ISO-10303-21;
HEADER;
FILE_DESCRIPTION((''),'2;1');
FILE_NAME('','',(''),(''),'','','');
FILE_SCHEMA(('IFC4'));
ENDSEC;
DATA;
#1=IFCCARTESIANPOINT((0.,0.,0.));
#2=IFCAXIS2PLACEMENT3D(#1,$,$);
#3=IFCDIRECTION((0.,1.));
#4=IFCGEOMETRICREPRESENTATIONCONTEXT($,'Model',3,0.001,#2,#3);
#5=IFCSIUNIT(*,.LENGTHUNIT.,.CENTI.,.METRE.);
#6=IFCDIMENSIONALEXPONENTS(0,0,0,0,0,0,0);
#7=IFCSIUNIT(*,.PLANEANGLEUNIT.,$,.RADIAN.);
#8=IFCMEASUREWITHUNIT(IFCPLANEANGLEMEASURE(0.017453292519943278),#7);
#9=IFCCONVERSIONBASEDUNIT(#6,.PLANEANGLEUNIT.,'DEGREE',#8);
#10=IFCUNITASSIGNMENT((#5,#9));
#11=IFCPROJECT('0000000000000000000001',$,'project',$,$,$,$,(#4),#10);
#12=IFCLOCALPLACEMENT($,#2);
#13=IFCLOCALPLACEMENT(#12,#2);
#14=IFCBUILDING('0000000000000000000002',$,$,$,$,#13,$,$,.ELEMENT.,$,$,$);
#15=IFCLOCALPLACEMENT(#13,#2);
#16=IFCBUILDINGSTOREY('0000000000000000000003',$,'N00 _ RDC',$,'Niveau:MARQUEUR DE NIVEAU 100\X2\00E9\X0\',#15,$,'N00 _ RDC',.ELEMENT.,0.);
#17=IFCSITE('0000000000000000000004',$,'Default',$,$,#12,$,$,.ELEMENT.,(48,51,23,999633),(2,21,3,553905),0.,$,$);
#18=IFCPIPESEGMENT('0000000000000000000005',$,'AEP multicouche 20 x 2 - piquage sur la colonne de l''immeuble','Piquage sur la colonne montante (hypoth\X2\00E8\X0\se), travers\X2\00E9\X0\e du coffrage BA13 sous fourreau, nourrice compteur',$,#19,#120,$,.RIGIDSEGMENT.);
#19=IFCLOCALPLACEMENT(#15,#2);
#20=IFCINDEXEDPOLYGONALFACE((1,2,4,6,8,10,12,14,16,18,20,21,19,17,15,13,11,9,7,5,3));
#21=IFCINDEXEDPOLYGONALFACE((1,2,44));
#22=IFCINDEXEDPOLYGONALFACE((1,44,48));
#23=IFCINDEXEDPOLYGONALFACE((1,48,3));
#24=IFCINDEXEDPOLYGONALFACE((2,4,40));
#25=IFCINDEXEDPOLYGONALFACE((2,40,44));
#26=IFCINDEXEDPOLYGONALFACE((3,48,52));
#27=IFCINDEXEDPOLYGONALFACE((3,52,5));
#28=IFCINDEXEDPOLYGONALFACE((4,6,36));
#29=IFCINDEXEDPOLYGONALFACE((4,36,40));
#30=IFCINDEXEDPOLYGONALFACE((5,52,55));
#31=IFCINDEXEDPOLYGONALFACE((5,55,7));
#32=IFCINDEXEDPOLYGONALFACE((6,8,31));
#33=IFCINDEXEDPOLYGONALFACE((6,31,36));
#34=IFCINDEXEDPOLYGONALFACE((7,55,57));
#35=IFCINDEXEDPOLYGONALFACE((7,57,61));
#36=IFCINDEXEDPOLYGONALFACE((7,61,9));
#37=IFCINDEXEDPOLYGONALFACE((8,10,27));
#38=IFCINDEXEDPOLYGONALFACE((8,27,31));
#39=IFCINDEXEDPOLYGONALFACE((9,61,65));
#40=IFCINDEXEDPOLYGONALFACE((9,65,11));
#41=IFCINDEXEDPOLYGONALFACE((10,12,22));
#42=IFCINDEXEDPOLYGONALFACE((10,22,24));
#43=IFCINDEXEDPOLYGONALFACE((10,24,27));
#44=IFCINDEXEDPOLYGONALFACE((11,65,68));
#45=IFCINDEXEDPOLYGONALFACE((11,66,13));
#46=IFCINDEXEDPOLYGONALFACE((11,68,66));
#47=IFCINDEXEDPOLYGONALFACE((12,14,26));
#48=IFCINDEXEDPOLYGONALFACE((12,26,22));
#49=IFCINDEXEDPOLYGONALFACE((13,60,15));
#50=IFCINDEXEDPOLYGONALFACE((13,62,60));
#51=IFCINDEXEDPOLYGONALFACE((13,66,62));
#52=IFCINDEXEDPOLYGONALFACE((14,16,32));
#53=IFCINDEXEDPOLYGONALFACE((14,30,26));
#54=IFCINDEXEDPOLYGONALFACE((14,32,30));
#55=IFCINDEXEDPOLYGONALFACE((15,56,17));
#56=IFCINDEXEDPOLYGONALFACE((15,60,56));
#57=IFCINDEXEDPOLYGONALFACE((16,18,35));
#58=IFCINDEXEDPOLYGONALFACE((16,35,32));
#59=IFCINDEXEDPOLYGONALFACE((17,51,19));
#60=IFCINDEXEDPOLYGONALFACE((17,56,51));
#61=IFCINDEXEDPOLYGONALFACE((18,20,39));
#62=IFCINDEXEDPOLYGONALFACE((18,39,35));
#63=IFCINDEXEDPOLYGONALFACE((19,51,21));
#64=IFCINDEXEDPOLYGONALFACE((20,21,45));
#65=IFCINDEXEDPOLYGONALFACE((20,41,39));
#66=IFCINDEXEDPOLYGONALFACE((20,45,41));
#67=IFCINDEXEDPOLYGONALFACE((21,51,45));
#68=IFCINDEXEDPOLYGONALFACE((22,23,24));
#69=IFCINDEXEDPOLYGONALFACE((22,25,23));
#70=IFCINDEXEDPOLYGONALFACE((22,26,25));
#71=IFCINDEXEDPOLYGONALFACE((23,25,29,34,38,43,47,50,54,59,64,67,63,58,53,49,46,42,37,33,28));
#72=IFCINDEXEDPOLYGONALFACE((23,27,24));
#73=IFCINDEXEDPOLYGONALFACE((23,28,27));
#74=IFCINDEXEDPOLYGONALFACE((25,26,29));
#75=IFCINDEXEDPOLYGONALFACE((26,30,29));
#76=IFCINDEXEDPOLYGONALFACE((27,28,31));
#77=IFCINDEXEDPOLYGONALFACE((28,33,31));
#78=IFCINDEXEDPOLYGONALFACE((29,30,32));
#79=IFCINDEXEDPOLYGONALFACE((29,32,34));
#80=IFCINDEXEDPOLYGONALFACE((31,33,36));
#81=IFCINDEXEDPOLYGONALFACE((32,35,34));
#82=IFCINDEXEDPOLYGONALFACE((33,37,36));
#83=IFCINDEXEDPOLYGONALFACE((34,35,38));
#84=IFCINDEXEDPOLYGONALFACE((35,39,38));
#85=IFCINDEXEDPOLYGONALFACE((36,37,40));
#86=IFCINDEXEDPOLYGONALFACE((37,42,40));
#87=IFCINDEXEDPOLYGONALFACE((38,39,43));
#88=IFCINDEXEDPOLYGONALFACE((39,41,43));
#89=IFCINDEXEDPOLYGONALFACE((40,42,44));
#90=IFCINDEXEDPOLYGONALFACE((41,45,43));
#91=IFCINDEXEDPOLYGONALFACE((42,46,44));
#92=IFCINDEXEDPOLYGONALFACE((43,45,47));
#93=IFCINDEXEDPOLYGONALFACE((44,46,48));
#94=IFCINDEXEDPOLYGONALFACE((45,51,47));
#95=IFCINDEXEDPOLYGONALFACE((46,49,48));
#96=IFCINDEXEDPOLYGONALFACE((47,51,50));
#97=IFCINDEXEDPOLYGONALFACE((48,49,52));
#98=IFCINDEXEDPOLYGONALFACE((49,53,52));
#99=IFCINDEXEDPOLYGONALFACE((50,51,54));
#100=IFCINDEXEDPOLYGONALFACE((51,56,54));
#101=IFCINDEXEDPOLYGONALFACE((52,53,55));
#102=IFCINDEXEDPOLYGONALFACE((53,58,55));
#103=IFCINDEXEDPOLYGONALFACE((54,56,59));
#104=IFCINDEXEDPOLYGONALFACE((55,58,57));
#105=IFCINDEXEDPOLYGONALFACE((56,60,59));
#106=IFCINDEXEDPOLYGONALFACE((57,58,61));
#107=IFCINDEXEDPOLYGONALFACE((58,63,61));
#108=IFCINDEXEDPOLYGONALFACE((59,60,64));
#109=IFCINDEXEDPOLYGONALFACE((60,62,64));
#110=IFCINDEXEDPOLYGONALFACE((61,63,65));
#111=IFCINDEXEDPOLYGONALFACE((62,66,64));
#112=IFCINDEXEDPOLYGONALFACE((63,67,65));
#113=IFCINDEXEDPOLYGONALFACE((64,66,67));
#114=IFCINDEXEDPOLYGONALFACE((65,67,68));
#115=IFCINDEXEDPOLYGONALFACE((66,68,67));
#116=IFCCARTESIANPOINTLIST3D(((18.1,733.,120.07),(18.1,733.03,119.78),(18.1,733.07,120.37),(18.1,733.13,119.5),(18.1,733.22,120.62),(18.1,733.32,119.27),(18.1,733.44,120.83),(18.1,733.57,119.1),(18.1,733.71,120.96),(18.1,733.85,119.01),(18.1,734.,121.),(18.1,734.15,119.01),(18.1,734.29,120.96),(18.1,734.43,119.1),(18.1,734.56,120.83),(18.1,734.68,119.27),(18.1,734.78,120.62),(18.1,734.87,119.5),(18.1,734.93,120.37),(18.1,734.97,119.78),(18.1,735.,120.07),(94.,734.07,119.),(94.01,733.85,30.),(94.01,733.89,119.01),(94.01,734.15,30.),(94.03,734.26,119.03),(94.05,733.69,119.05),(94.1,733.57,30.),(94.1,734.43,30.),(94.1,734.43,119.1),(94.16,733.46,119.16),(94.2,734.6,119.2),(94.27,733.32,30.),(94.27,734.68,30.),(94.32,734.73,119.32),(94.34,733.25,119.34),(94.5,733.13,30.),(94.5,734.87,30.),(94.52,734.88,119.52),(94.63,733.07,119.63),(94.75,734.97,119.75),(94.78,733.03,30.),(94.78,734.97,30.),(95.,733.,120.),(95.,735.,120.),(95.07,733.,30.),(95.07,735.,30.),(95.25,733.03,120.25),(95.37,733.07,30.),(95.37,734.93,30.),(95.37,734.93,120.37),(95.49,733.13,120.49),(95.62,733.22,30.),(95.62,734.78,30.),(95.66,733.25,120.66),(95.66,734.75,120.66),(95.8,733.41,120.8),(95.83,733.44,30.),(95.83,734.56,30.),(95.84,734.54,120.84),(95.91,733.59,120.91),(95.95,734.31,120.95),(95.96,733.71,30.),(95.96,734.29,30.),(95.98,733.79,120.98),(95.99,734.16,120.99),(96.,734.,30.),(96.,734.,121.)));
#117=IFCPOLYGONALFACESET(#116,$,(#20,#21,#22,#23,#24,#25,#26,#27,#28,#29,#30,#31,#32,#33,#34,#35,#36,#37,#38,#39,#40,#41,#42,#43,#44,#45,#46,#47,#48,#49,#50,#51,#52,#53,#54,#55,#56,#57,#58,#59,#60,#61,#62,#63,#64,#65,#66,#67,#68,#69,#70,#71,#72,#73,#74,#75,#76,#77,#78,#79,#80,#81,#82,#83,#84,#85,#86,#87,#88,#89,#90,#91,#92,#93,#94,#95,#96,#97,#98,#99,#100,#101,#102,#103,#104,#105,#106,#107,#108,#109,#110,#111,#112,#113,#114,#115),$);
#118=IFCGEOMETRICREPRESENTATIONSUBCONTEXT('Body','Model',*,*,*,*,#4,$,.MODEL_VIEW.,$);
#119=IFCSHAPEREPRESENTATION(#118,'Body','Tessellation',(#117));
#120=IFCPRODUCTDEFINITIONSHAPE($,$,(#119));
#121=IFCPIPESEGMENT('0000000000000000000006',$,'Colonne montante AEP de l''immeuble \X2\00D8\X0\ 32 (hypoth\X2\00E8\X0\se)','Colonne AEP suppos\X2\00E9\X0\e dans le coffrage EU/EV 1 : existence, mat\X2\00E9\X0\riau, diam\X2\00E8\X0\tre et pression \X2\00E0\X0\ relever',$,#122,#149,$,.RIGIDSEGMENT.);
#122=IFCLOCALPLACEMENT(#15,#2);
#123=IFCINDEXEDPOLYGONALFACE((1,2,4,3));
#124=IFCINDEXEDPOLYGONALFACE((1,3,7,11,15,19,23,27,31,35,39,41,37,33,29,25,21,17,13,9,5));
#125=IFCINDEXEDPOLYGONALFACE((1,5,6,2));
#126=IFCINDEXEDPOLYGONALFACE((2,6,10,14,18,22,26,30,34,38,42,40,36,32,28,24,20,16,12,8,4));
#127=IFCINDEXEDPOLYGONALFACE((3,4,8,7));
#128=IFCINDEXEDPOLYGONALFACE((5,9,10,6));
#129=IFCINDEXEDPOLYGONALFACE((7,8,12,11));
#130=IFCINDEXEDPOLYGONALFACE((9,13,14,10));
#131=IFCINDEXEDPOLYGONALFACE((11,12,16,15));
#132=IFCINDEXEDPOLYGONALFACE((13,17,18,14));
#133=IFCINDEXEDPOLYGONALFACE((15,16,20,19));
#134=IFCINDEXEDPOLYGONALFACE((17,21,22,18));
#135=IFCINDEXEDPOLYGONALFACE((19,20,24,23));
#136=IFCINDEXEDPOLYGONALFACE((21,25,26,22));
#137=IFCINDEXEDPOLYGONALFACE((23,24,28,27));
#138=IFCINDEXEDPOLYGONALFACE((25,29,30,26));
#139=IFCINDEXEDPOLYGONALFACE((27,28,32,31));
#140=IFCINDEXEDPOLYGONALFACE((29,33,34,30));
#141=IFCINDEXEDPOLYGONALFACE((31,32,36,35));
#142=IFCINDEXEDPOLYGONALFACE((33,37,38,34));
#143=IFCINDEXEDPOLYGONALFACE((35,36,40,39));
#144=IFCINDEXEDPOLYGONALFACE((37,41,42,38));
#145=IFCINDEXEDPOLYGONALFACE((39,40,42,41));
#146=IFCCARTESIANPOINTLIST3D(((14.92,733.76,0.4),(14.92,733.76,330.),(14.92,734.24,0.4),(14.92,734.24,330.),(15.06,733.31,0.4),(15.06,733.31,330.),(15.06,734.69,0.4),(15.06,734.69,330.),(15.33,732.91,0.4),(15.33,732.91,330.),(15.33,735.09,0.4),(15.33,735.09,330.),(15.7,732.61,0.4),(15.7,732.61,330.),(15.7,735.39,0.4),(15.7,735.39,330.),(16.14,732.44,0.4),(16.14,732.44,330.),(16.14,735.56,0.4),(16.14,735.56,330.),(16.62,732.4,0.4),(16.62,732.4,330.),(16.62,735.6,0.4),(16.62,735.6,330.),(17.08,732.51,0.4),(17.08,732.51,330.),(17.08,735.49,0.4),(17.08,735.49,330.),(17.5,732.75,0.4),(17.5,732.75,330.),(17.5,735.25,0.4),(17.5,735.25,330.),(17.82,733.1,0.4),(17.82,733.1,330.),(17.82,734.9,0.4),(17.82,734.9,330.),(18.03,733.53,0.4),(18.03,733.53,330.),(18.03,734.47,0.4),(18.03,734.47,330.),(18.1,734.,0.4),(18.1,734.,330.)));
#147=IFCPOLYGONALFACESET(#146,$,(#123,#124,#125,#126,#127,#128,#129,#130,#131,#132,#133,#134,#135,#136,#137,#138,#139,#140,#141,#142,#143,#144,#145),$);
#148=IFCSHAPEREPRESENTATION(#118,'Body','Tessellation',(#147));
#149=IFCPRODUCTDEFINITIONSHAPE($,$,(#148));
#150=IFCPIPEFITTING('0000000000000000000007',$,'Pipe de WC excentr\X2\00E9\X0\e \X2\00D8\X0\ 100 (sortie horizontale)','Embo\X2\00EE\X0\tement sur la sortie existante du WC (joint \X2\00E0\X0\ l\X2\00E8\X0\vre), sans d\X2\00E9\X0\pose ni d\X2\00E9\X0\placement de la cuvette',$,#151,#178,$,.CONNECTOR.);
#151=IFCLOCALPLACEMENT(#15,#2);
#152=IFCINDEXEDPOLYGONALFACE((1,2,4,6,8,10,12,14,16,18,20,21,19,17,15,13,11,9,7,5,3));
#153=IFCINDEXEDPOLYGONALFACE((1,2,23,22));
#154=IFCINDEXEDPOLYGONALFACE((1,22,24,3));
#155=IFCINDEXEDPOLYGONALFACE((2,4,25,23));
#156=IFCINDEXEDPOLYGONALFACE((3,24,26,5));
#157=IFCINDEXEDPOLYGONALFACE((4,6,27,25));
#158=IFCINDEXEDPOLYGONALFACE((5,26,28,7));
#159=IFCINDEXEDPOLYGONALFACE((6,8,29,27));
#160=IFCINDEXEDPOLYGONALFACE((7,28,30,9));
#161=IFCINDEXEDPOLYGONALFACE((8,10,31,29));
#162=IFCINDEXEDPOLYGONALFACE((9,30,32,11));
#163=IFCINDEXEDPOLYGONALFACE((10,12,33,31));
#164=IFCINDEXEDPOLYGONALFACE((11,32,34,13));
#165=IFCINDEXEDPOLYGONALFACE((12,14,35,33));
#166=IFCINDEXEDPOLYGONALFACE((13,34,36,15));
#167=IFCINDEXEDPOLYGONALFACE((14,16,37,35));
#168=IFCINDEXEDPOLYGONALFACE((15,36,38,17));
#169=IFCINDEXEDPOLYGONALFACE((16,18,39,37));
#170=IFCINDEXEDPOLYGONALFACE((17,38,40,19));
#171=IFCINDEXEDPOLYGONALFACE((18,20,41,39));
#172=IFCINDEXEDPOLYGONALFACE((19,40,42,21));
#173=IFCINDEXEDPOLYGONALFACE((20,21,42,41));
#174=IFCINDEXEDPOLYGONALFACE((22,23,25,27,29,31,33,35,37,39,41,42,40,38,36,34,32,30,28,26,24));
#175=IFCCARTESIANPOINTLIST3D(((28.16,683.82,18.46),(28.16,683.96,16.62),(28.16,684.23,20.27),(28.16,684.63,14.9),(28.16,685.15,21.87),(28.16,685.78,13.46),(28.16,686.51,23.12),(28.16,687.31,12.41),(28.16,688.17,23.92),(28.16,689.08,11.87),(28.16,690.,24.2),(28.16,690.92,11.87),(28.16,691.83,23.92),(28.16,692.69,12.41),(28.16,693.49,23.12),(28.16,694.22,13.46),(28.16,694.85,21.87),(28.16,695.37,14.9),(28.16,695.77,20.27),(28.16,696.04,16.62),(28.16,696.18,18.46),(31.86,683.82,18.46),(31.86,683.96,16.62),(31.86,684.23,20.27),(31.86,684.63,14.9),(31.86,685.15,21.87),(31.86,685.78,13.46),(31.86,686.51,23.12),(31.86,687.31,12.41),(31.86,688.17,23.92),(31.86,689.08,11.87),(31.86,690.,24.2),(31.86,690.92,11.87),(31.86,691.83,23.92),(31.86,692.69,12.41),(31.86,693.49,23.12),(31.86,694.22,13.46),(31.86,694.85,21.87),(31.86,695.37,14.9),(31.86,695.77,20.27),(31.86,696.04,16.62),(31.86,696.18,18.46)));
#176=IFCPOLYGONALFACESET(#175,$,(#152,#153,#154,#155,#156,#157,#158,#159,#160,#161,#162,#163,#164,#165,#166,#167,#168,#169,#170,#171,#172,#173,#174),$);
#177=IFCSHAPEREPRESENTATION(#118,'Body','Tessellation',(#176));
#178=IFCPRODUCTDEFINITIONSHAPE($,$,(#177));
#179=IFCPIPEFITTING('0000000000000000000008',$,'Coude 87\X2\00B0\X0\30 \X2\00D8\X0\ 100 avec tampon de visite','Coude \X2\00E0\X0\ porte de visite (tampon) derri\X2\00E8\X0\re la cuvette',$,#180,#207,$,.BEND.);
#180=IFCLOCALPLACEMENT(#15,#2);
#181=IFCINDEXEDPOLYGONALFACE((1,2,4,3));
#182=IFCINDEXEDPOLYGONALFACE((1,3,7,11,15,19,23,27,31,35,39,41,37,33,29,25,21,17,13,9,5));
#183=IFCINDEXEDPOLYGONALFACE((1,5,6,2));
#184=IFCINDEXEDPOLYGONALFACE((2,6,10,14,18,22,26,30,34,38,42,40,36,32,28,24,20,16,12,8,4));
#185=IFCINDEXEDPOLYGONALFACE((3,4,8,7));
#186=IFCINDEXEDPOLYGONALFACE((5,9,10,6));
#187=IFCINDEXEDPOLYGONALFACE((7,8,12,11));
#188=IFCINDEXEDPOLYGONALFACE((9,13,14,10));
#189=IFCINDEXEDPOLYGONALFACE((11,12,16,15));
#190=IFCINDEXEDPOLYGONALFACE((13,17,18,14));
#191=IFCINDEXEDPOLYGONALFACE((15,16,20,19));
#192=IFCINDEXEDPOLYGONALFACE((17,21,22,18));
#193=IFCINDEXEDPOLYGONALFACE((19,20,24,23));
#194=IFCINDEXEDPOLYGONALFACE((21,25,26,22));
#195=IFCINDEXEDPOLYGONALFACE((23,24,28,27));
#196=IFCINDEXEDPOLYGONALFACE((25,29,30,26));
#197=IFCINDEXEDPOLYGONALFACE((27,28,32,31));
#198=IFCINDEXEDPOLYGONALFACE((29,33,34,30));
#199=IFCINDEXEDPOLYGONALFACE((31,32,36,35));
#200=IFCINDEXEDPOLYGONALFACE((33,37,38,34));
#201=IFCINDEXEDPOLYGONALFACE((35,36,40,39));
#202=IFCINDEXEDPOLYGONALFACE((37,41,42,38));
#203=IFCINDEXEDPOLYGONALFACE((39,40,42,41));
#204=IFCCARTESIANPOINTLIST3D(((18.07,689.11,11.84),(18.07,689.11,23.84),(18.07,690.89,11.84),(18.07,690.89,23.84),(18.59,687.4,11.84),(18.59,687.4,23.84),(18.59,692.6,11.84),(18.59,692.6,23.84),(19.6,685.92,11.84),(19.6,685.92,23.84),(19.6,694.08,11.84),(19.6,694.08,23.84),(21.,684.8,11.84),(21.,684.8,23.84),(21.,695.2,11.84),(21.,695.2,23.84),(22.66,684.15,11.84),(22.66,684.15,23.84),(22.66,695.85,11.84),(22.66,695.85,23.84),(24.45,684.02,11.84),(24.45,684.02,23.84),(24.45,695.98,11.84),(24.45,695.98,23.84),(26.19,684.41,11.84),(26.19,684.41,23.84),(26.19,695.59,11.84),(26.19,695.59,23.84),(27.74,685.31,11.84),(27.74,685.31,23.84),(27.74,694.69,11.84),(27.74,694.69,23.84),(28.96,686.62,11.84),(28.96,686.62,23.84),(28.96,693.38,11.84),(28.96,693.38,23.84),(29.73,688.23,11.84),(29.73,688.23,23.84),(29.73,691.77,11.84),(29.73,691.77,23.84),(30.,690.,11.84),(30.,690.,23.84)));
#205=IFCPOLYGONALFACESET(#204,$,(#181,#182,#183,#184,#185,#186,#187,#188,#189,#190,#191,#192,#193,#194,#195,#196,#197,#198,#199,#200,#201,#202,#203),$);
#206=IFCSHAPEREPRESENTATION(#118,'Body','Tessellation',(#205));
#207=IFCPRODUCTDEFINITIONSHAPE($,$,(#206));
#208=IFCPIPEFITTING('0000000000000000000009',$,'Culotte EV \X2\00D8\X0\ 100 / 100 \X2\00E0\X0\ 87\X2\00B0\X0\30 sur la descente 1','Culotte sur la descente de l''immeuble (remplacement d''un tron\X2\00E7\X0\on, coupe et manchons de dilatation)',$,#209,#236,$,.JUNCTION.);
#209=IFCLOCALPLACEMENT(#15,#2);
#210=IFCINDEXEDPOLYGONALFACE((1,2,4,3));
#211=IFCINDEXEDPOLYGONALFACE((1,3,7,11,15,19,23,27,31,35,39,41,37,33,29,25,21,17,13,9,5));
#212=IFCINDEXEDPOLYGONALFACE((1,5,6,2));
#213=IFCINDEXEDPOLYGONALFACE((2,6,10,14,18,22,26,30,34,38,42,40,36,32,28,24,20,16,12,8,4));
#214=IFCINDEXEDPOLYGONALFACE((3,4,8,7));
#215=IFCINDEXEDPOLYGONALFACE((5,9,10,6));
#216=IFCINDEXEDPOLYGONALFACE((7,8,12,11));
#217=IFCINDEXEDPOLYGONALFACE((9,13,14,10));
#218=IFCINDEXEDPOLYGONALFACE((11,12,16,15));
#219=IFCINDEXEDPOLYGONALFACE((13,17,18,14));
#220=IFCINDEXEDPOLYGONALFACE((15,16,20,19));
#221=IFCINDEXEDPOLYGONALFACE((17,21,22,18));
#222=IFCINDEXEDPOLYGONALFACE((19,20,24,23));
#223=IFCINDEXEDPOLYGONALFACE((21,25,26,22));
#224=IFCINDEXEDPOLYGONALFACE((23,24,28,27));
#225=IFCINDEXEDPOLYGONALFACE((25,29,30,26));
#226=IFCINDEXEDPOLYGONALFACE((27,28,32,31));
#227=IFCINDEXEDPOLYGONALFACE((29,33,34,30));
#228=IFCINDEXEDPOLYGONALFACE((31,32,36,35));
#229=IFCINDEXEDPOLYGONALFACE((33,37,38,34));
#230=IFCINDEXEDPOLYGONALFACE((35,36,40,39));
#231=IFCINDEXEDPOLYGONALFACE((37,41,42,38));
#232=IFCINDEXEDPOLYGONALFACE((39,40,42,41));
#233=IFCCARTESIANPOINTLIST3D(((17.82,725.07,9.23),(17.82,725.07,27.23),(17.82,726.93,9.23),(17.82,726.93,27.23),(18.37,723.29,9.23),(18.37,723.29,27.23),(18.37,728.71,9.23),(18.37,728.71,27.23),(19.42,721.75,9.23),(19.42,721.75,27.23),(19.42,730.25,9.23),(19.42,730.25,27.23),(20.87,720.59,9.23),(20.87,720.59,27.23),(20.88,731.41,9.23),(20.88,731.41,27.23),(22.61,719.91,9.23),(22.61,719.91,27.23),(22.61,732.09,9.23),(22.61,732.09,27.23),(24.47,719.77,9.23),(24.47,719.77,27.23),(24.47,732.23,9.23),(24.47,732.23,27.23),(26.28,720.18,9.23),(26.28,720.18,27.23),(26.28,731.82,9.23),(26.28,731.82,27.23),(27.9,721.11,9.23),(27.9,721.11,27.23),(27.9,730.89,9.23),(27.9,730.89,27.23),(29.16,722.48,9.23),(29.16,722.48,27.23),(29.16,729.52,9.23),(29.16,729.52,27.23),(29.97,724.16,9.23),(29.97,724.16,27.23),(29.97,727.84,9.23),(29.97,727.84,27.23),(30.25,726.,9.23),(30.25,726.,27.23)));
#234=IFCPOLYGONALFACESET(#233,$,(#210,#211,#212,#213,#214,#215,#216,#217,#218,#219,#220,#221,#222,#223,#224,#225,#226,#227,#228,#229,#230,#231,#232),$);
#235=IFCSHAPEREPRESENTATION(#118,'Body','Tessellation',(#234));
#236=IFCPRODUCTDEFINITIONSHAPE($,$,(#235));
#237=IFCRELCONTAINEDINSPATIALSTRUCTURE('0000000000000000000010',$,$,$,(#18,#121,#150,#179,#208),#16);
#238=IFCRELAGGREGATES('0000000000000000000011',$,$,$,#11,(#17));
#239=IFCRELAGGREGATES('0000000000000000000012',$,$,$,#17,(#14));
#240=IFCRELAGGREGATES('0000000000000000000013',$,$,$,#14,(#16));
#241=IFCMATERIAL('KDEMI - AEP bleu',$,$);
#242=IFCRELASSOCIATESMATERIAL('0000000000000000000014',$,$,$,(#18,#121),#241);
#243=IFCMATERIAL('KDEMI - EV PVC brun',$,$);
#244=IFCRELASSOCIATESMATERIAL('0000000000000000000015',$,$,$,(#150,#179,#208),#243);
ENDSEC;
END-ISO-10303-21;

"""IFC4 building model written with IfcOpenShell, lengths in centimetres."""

from ifc_helpers import new_model, entity, si_unit, converted_unit, direction, frame, frame_2d, origin, origin_with_axes, place, context, subcontext, project, spatial, circle, extrude, material, element, save


model = new_model("IFC4")

# Units and contexts
model_context = context("Model", 3, precision=0.001, world=origin(), true_north=direction((0.0, 1.0)))
body_context = subcontext(model_context, "Body", "Model", "MODEL_VIEW")
ifc_project = project(units=[si_unit("LENGTHUNIT", "METRE", prefix="CENTI"), converted_unit("PLANEANGLEUNIT", "DEGREE", entity("IfcPlaneAngleMeasure", 0.017453292519943278), si_unit("PLANEANGLEUNIT", "RADIAN"), dimensions=[0, 0, 0, 0, 0, 0, 0])], contexts=[model_context])

# Site, building, storey
site_placement = place(None, origin())
site = spatial("IfcSite", under=ifc_project, at=site_placement, Name="Default", CompositionType="ELEMENT", RefLatitude=(48, 51, 23, 999633), RefLongitude=(2, 21, 3, 553905), RefElevation=0.0)
building_placement = place(site_placement, origin())
building = spatial("IfcBuilding", under=site, at=building_placement, CompositionType="ELEMENT")
storey_placement = place(building_placement, origin())
storey = spatial("IfcBuildingStorey", under=building, at=storey_placement, Name="N00 _ RDC", ObjectType="Niveau:MARQUEUR DE NIVEAU 100é", LongName="N00 _ RDC", CompositionType="ELEMENT", Elevation=0.0)

# Pipe segments
ifc_material_1 = material(Name="KDEMI - EV PVC brun")
ifc_material_2 = material(Name="KDEMI - AEP bleu")
pipe_segment_1_placement = place(storey_placement, origin_with_axes())
element("IfcPipeSegment", 1, at=pipe_segment_1_placement, inside=storey, material=ifc_material_2, Name="AEP multicouche 20 x 2 - piquage sur la colonne de l'immeuble", Description="Piquage sur la colonne montante (hypothèse), traversée du coffrage BA13 sous fourreau, nourrice compteur", PredefinedType="RIGIDSEGMENT", context=body_context, shape_type="AdvancedSweptSolid", body=[
    entity("IfcSweptDiskSolid", entity("IfcPolyline", [entity("IfcCartesianPoint", [18.1, 734.0, 120.0]), entity("IfcCartesianPoint", [95.0, 734.0, 120.0]), entity("IfcCartesianPoint", [95.0, 734.0, 30.0])]), 1.0),
])
pipe_segment_2_placement = place(storey_placement, origin_with_axes())
element("IfcPipeSegment", 2, at=pipe_segment_2_placement, inside=storey, material=ifc_material_2, Name="Colonne montante AEP de l'immeuble Ø 32 (hypothèse)", Description="Colonne AEP supposée dans le coffrage EU/EV 1 : existence, matériau, diamètre et pression à relever", PredefinedType="RIGIDSEGMENT", context=body_context, shape_type="SweptSolid", body=[
    extrude(circle(Radius=1.6, at=frame_2d((16.5, 734.0))), frame((0.0, 0.0, 0.4)), (0.0, 0.0, 1.0), 329.6),
])

# Pipe fittings
pipe_fitting_1_placement = place(storey_placement, origin_with_axes())
element("IfcPipeFitting", 3, at=pipe_fitting_1_placement, inside=storey, material=ifc_material_1, Name="Pipe de WC excentrée Ø 100 (sortie horizontale)", Description="Emboîtement sur la sortie existante du WC (joint à lèvre), sans dépose ni déplacement de la cuvette", PredefinedType="CONNECTOR", context=body_context, shape_type="AdvancedSweptSolid", body=[
    entity("IfcSweptDiskSolid", entity("IfcPolyline", [entity("IfcCartesianPoint", [28.16, 690.0, 18.0]), entity("IfcCartesianPoint", [31.86, 690.0, 18.0])]), 6.2),
])
pipe_fitting_2_placement = place(storey_placement, origin_with_axes())
element("IfcPipeFitting", 4, at=pipe_fitting_2_placement, inside=storey, material=ifc_material_1, Name="Coude 87°30 Ø 100 avec tampon de visite", Description="Coude à porte de visite (tampon) derrière la cuvette", PredefinedType="BEND", context=body_context, shape_type="SweptSolid", body=[
    extrude(circle(Radius=6.0, at=frame_2d((24.0, 690.0))), frame((0.0, 0.0, 11.84)), (0.0, 0.0, 1.0), 12.0),
])
pipe_fitting_3_placement = place(storey_placement, origin_with_axes())
element("IfcPipeFitting", 5, at=pipe_fitting_3_placement, inside=storey, material=ifc_material_1, Name="Culotte EV Ø 100 / 100 à 87°30 sur la descente 1", Description="Culotte sur la descente de l'immeuble (remplacement d'un tronçon, coupe et manchons de dilatation)", PredefinedType="JUNCTION", context=body_context, shape_type="SweptSolid", body=[
    extrude(circle(Radius=6.25, at=frame_2d((24.0, 726.0))), frame((0.0, 0.0, 9.23)), (0.0, 0.0, 1.0), 18.0),
])

save(model, "model.ifc")
